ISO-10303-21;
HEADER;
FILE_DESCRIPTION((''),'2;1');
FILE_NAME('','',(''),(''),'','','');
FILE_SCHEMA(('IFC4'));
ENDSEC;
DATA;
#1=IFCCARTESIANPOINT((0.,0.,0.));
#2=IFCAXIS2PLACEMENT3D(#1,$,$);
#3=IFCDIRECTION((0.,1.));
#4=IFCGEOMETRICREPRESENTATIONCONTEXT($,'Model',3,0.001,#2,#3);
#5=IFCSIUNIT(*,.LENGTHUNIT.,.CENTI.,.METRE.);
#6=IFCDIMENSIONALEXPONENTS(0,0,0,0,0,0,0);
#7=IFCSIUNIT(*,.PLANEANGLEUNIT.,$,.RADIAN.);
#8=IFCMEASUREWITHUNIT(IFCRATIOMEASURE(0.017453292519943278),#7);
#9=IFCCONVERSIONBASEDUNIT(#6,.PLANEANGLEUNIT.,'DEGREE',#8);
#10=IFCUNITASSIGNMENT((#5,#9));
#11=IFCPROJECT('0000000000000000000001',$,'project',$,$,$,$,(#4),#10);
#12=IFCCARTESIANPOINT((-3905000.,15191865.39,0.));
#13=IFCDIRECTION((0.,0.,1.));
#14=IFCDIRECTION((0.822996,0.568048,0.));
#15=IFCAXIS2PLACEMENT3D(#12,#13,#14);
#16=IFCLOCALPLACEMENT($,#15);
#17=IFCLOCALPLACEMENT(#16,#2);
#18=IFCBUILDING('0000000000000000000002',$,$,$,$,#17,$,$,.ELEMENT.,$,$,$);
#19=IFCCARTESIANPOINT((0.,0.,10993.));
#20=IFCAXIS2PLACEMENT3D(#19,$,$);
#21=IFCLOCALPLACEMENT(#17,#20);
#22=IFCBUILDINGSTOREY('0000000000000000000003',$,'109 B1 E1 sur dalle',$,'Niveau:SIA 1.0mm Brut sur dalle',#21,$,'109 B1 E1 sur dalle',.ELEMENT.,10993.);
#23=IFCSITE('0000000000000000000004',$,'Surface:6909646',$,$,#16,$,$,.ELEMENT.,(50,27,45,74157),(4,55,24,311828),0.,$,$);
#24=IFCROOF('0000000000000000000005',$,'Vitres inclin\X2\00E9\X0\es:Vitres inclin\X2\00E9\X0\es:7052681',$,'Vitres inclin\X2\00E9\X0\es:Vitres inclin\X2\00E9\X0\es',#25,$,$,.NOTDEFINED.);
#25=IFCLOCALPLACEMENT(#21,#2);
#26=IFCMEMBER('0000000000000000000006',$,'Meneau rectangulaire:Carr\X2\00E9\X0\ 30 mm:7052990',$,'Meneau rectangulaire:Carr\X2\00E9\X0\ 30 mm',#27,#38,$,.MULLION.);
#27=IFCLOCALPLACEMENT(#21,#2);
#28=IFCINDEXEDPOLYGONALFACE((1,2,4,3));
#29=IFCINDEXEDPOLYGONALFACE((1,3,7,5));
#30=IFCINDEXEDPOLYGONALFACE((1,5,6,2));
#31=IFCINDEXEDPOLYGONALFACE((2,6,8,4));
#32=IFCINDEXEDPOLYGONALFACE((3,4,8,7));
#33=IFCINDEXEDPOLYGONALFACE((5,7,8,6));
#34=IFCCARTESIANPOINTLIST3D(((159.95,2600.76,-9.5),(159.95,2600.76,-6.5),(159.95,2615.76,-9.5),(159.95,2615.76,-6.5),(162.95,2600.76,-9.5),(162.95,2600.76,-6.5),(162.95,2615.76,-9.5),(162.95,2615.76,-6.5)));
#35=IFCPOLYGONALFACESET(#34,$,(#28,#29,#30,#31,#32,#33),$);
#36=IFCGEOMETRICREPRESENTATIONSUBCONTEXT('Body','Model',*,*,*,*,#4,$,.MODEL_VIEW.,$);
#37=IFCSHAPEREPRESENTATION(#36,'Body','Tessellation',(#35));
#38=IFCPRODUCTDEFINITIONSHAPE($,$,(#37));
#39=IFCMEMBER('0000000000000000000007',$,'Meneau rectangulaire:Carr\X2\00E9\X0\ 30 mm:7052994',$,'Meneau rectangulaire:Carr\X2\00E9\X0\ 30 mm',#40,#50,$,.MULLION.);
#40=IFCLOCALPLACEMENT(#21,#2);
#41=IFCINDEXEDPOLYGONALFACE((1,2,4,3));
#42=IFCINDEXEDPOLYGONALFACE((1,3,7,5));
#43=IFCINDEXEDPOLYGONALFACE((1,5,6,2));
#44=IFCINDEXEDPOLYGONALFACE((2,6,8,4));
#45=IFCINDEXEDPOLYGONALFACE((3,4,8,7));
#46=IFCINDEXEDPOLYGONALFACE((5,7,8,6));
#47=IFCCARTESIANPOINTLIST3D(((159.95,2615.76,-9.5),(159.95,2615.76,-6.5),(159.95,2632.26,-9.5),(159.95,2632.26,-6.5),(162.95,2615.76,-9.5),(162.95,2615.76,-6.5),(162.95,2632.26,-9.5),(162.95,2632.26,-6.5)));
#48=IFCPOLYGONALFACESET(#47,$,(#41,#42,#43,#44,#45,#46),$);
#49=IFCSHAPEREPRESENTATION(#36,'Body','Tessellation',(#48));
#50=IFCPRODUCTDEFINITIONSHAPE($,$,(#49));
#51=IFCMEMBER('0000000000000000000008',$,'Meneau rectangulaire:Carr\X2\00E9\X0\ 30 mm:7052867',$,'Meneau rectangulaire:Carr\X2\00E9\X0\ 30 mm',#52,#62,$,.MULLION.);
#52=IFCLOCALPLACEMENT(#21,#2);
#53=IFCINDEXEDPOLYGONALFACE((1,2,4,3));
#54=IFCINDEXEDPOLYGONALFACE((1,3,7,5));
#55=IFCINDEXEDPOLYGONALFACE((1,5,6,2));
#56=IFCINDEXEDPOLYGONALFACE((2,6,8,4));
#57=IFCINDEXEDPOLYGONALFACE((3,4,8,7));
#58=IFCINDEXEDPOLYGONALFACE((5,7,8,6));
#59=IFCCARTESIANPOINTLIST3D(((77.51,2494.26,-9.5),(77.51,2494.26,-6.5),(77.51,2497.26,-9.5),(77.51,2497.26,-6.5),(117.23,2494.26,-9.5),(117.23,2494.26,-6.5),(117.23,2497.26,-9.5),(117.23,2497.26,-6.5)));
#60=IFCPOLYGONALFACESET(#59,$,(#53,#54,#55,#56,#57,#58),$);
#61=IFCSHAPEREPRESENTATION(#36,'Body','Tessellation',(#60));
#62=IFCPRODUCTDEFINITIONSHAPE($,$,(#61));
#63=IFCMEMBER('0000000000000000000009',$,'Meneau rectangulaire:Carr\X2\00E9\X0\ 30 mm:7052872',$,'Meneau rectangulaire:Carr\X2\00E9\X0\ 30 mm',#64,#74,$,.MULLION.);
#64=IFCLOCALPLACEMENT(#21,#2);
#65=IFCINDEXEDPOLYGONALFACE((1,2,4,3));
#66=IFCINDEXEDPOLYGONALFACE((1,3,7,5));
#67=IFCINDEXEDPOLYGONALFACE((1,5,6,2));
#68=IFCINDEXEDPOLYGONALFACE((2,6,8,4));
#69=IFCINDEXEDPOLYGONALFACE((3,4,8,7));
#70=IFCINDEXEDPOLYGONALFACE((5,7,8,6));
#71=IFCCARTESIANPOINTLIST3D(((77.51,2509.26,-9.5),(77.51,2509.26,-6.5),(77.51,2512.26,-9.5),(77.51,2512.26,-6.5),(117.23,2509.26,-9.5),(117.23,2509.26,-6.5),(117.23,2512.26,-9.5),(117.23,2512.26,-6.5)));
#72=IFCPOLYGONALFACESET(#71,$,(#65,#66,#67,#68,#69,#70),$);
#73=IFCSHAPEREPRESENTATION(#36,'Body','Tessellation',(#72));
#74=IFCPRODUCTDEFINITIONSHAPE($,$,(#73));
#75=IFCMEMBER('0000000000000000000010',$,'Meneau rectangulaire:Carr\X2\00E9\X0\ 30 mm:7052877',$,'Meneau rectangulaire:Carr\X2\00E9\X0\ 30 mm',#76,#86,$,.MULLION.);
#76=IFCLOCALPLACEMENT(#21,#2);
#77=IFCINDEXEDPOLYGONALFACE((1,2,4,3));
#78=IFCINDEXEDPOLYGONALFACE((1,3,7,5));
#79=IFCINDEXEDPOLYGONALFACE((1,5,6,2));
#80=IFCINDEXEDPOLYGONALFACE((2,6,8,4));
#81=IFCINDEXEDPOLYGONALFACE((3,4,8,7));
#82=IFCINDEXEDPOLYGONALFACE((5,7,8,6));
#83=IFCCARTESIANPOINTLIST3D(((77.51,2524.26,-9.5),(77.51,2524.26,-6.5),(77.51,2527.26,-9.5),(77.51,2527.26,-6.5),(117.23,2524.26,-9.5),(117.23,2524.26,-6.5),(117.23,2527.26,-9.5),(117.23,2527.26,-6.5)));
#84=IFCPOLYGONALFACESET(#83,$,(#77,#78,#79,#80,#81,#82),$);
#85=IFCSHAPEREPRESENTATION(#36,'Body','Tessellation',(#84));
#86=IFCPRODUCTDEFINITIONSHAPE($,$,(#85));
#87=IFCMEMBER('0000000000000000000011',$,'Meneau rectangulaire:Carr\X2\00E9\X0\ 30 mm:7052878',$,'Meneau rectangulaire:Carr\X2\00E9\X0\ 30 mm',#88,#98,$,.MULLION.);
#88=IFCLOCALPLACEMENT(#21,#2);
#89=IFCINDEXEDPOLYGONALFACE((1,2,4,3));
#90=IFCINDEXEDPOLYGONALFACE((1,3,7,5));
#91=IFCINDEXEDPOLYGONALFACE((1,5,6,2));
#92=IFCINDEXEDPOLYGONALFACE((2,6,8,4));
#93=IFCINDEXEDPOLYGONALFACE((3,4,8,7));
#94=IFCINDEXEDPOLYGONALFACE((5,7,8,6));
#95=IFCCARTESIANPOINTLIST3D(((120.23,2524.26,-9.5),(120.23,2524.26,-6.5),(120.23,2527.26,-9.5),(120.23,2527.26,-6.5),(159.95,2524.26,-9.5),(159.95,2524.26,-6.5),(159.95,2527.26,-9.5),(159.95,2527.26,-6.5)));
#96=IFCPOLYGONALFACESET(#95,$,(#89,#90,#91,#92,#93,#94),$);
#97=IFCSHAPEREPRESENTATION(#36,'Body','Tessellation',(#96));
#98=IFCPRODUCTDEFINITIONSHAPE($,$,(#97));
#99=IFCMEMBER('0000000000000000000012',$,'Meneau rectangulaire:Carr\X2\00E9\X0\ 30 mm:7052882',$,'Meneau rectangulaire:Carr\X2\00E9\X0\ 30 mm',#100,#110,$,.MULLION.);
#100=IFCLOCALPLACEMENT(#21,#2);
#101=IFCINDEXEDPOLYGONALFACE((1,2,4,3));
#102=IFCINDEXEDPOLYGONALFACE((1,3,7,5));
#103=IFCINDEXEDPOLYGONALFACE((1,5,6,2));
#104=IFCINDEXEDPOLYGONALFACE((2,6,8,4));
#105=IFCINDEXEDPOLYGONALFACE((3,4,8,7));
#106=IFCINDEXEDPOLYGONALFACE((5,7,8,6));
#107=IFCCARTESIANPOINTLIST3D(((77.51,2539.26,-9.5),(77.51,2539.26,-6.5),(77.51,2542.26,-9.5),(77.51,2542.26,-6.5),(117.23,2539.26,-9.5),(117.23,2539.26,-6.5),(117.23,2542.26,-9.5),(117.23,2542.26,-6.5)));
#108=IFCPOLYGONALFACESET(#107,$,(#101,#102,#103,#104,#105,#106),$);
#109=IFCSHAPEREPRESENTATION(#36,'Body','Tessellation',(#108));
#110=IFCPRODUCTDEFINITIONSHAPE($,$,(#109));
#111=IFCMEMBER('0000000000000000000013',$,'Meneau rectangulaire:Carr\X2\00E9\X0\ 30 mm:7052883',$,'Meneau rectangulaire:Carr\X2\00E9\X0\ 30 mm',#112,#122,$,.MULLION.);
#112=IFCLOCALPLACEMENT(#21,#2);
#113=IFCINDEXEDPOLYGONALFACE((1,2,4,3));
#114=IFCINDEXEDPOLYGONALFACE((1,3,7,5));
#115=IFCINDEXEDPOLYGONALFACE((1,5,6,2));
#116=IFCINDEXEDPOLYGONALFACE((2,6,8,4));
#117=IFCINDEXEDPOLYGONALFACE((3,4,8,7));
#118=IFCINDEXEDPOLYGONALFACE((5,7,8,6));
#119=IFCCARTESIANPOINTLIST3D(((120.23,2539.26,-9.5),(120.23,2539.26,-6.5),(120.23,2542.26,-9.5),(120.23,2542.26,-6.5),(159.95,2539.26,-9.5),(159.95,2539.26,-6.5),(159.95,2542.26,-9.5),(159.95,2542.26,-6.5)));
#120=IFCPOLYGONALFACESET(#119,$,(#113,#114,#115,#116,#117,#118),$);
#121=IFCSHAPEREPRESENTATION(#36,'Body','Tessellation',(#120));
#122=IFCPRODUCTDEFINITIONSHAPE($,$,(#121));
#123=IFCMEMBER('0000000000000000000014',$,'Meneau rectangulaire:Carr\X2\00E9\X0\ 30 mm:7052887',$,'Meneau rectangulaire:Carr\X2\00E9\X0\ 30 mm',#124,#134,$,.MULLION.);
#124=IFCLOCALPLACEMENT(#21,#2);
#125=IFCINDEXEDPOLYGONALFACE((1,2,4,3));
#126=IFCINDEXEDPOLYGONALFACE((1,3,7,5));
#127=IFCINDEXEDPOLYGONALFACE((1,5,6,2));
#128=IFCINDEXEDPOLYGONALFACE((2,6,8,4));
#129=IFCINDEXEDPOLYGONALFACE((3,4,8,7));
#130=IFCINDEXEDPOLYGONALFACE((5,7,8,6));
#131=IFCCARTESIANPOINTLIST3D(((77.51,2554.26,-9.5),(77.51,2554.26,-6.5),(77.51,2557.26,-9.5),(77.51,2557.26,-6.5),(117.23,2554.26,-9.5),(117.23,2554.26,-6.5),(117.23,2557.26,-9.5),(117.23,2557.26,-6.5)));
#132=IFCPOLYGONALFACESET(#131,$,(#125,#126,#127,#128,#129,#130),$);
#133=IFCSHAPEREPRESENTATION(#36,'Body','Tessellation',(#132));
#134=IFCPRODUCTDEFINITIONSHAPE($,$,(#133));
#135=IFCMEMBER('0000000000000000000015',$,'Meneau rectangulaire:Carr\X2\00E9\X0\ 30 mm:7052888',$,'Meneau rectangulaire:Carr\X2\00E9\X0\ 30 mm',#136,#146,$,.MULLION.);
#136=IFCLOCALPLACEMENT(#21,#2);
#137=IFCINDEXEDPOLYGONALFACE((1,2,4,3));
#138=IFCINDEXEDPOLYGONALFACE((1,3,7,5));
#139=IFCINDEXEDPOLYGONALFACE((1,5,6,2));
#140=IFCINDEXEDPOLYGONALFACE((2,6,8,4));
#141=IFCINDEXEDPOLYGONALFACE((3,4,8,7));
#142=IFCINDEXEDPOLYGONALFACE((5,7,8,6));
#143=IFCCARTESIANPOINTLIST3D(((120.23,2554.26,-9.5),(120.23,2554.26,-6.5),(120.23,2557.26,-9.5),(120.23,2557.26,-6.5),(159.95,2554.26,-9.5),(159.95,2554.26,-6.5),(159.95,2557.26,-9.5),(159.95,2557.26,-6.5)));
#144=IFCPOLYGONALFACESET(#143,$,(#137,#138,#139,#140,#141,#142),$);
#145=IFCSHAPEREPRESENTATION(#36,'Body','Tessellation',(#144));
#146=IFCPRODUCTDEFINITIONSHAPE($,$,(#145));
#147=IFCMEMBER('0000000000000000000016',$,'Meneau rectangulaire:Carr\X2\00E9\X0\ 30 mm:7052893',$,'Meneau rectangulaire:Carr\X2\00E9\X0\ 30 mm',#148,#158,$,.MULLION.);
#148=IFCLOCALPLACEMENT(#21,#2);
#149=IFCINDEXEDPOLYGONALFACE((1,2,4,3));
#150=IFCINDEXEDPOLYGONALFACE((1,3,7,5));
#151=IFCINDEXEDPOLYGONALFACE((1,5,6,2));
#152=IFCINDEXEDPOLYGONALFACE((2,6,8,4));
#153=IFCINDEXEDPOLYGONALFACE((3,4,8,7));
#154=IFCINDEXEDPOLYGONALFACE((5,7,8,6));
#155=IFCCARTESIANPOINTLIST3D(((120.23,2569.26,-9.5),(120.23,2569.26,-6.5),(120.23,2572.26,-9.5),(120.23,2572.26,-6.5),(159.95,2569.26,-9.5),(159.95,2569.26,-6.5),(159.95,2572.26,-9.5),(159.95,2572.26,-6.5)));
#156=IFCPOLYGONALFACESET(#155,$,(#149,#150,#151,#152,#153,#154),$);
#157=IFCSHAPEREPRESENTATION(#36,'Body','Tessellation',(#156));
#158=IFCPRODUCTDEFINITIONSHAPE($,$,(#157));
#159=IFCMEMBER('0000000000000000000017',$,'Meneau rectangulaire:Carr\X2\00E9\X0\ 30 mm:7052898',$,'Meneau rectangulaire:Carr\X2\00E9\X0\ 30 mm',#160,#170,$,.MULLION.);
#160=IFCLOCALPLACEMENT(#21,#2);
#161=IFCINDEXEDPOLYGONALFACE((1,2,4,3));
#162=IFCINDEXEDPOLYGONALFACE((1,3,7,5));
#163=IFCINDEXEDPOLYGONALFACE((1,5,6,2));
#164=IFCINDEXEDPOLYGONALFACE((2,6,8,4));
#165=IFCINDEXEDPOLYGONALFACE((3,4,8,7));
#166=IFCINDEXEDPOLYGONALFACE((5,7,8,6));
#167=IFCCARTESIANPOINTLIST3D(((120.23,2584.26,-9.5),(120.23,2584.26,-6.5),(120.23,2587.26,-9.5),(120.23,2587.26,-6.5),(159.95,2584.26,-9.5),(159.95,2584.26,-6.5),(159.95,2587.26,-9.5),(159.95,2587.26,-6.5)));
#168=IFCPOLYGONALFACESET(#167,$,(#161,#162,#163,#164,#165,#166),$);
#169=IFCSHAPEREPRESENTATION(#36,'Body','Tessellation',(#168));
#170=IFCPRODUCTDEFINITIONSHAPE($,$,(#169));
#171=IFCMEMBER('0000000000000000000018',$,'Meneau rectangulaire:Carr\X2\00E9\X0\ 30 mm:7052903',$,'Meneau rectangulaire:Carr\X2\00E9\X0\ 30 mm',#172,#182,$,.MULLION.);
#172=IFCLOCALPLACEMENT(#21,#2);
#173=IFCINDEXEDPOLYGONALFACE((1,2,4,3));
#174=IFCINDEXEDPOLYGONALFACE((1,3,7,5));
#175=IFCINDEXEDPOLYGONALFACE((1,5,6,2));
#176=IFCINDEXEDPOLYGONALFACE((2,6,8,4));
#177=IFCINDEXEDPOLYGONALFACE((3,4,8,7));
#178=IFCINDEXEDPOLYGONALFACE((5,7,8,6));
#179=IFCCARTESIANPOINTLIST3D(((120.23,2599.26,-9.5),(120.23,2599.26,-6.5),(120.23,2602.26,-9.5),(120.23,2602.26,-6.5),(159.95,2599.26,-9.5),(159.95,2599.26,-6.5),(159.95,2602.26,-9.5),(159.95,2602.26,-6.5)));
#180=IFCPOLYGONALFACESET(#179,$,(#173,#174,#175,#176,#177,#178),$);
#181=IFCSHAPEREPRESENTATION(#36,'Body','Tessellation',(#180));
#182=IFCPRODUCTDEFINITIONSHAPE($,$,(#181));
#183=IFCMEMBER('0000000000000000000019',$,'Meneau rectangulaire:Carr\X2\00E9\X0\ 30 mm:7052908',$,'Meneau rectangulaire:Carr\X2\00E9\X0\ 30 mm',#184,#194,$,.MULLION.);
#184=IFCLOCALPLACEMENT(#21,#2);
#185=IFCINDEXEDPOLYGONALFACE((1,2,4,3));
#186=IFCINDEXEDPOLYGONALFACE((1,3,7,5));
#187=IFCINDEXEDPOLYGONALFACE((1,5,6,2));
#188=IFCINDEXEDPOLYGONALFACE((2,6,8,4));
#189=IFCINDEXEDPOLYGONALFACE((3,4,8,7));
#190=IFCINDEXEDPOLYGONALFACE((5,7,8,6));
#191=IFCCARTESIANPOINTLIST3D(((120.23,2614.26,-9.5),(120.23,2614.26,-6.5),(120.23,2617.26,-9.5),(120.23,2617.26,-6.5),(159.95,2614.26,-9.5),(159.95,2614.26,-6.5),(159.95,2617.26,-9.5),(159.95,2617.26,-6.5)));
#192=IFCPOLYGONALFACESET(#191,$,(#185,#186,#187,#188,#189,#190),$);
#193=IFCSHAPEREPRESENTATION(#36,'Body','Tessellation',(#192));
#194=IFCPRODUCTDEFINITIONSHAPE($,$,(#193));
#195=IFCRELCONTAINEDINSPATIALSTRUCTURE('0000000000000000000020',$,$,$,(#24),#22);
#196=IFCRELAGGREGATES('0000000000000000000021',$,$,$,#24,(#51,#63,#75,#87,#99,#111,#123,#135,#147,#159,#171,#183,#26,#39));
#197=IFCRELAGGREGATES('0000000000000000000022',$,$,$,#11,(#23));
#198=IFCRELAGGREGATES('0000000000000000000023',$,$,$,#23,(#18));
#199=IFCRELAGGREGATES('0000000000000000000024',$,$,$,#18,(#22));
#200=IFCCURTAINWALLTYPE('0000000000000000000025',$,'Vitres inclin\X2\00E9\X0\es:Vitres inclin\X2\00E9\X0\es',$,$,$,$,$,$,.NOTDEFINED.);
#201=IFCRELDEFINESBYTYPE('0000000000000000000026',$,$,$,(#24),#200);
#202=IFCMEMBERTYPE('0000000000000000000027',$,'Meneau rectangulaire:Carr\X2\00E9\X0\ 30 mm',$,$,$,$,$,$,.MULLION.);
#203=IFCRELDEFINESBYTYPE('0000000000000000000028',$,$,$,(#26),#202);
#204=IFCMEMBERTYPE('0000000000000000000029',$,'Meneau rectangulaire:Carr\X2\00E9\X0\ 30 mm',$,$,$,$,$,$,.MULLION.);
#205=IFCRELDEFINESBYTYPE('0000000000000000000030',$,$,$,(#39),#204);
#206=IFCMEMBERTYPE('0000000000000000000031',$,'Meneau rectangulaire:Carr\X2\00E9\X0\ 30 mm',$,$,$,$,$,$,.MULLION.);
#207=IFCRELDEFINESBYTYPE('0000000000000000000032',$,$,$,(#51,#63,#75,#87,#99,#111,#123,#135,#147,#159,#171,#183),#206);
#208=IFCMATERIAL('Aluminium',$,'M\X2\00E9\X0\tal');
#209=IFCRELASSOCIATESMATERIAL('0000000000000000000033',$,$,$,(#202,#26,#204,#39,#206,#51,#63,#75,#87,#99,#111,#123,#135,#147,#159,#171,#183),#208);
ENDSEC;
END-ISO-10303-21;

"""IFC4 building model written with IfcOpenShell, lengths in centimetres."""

from ifc_helpers import new_model, entity, si_unit, converted_unit, direction, frame, origin, place, context, subcontext, project, spatial, indexed_curve, outline, extrude, source, transform, mapped, material, type_object, type_shapes, element, aggregate, save


model = new_model("IFC4")

# Units and contexts
model_context = context("Model", 3, precision=0.001, world=origin(), true_north=direction((0.0, 1.0)))
body_context = subcontext(model_context, "Body", "Model", "MODEL_VIEW")
ifc_project = project(units=[si_unit("LENGTHUNIT", "METRE", prefix="CENTI"), converted_unit("PLANEANGLEUNIT", "DEGREE", entity("IfcRatioMeasure", 0.017453292519943278), si_unit("PLANEANGLEUNIT", "RADIAN"), dimensions=[0, 0, 0, 0, 0, 0, 0])], contexts=[model_context])

# Site, building, storey
site_placement = place(None, frame((-3905000.0, 15191865.39, 0.0), z_axis=(0.0, 0.0, 1.0), x_axis=(0.822996, 0.568048, 0.0)))
site = spatial("IfcSite", under=ifc_project, at=site_placement, Name="Surface:6909646", CompositionType="ELEMENT", RefLatitude=(50, 27, 45, 74157), RefLongitude=(4, 55, 24, 311828), RefElevation=0.0)
building_placement = place(site_placement, origin())
building = spatial("IfcBuilding", under=site, at=building_placement, CompositionType="ELEMENT")
storey_placement = place(building_placement, frame((0.0, 0.0, 10993.0)))
storey = spatial("IfcBuildingStorey", under=building, at=storey_placement, Name="109 B1 E1 sur dalle", ObjectType="Niveau:SIA 1.0mm Brut sur dalle", LongName="109 B1 E1 sur dalle", CompositionType="ELEMENT", Elevation=10993.0)

# Roof, members
curtain_wall_type = type_object("IfcCurtainWallType", Name="Vitres inclinées:Vitres inclinées", PredefinedType="NOTDEFINED")
roof_placement = place(storey_placement, frame((0.0, 0.0, -10993.0)))
roof = element("IfcRoof", 1, at=roof_placement, inside=storey, type_object=curtain_wall_type, Name="Vitres inclinées:Vitres inclinées:7052681", ObjectType="Vitres inclinées:Vitres inclinées", PredefinedType="NOTDEFINED")
ifc_material = material(Name="Aluminium", Category="Métal")
member_type_1 = type_object("IfcMemberType", Name="Meneau rectangulaire:Carré 30 mm", PredefinedType="MULLION", material=ifc_material)
shared_shape_1 = source(origin(), body_context, "Body", "SweptSolid", [
    extrude(outline(indexed_curve([(-1.5, -1.5), (1.5, -1.5), (1.5, 1.5), (-1.5, 1.5), (-1.5, -1.5)], self_intersect=False)), frame((0.0, 0.0, -15.0), z_axis=(0.0, 0.0, 1.0), x_axis=(0.0, -1.0, 0.0)), (0.0, 0.0, 1.0), 15.0),
])
type_shapes(member_type_1, [shared_shape_1])
member_1_placement = place(roof_placement, frame((161.45, 2615.76, 10985.0), z_axis=(0.0, 1.0, 0.0), x_axis=(1.0, 0.0, 0.0)))
member_1 = element("IfcMember", 2, at=member_1_placement, type_object=member_type_1, material=ifc_material, Name="Meneau rectangulaire:Carré 30 mm:7052990", ObjectType="Meneau rectangulaire:Carré 30 mm", PredefinedType="MULLION", context=body_context, shape_type="MappedRepresentation", body=[
    mapped(shared_shape_1, transform((0.0, 0.0, 0.0), scale=1.0)),
])
member_type_2 = type_object("IfcMemberType", Name="Meneau rectangulaire:Carré 30 mm", PredefinedType="MULLION", material=ifc_material)
shared_shape_2 = source(origin(), body_context, "Body", "SweptSolid", [
    extrude(outline(indexed_curve([(-1.5, -1.5), (1.5, -1.5), (1.5, 1.5), (-1.5, 1.5), (-1.5, -1.5)], self_intersect=False)), frame((0.0, 0.0, -16.5), z_axis=(0.0, 0.0, 1.0), x_axis=(0.0, -1.0, 0.0)), (0.0, 0.0, 1.0), 16.5),
])
type_shapes(member_type_2, [shared_shape_2])
member_2_placement = place(roof_placement, frame((161.45, 2632.26, 10985.0), z_axis=(0.0, 1.0, 0.0), x_axis=(1.0, 0.0, 0.0)))
member_2 = element("IfcMember", 3, at=member_2_placement, type_object=member_type_2, material=ifc_material, Name="Meneau rectangulaire:Carré 30 mm:7052994", ObjectType="Meneau rectangulaire:Carré 30 mm", PredefinedType="MULLION", context=body_context, shape_type="MappedRepresentation", body=[
    mapped(shared_shape_2, transform((0.0, 0.0, 0.0), scale=1.0)),
])
member_type_3 = type_object("IfcMemberType", Name="Meneau rectangulaire:Carré 30 mm", PredefinedType="MULLION", material=ifc_material)
shared_shape_3 = source(origin(), body_context, "Body", "SweptSolid", [
    extrude(outline(indexed_curve([(-1.5, -1.5), (1.5, -1.5), (1.5, 1.5), (-1.5, 1.5), (-1.5, -1.5)], self_intersect=False)), frame((0.0, 0.0, -39.72), z_axis=(0.0, 0.0, 1.0), x_axis=(0.0, -1.0, 0.0)), (0.0, 0.0, 1.0), 39.72),
])
type_shapes(member_type_3, [shared_shape_3])
member_3_placement = place(roof_placement, frame((77.51, 2495.76, 10985.0), z_axis=(-1.0, 0.0, 0.0), x_axis=(0.0, 1.0, 0.0)))
member_3 = element("IfcMember", 4, at=member_3_placement, type_object=member_type_3, material=ifc_material, Name="Meneau rectangulaire:Carré 30 mm:7052867", ObjectType="Meneau rectangulaire:Carré 30 mm", PredefinedType="MULLION", context=body_context, shape_type="MappedRepresentation", body=[
    mapped(shared_shape_3, transform((0.0, 0.0, 0.0), scale=1.0)),
])
member_4_placement = place(roof_placement, frame((77.51, 2510.76, 10985.0), z_axis=(-1.0, 0.0, 0.0), x_axis=(0.0, 1.0, 0.0)))
member_4 = element("IfcMember", 5, at=member_4_placement, type_object=member_type_3, material=ifc_material, Name="Meneau rectangulaire:Carré 30 mm:7052872", ObjectType="Meneau rectangulaire:Carré 30 mm", PredefinedType="MULLION", context=body_context, shape_type="MappedRepresentation", body=[
    mapped(shared_shape_3, transform((0.0, 0.0, 0.0), scale=1.0)),
])
member_5_placement = place(roof_placement, frame((77.51, 2525.76, 10985.0), z_axis=(-1.0, 0.0, 0.0), x_axis=(0.0, 1.0, 0.0)))
member_5 = element("IfcMember", 6, at=member_5_placement, type_object=member_type_3, material=ifc_material, Name="Meneau rectangulaire:Carré 30 mm:7052877", ObjectType="Meneau rectangulaire:Carré 30 mm", PredefinedType="MULLION", context=body_context, shape_type="MappedRepresentation", body=[
    mapped(shared_shape_3, transform((0.0, 0.0, 0.0), scale=1.0)),
])
member_6_placement = place(roof_placement, frame((120.23, 2525.76, 10985.0), z_axis=(-1.0, 0.0, 0.0), x_axis=(0.0, 1.0, 0.0)))
member_6 = element("IfcMember", 7, at=member_6_placement, type_object=member_type_3, material=ifc_material, Name="Meneau rectangulaire:Carré 30 mm:7052878", ObjectType="Meneau rectangulaire:Carré 30 mm", PredefinedType="MULLION", context=body_context, shape_type="MappedRepresentation", body=[
    mapped(shared_shape_3, transform((0.0, 0.0, 0.0), scale=1.0)),
])
member_7_placement = place(roof_placement, frame((77.51, 2540.76, 10985.0), z_axis=(-1.0, 0.0, 0.0), x_axis=(0.0, 1.0, 0.0)))
member_7 = element("IfcMember", 8, at=member_7_placement, type_object=member_type_3, material=ifc_material, Name="Meneau rectangulaire:Carré 30 mm:7052882", ObjectType="Meneau rectangulaire:Carré 30 mm", PredefinedType="MULLION", context=body_context, shape_type="MappedRepresentation", body=[
    mapped(shared_shape_3, transform((0.0, 0.0, 0.0), scale=1.0)),
])
member_8_placement = place(roof_placement, frame((120.23, 2540.76, 10985.0), z_axis=(-1.0, 0.0, 0.0), x_axis=(0.0, 1.0, 0.0)))
member_8 = element("IfcMember", 9, at=member_8_placement, type_object=member_type_3, material=ifc_material, Name="Meneau rectangulaire:Carré 30 mm:7052883", ObjectType="Meneau rectangulaire:Carré 30 mm", PredefinedType="MULLION", context=body_context, shape_type="MappedRepresentation", body=[
    mapped(shared_shape_3, transform((0.0, 0.0, 0.0), scale=1.0)),
])
member_9_placement = place(roof_placement, frame((77.51, 2555.76, 10985.0), z_axis=(-1.0, 0.0, 0.0), x_axis=(0.0, 1.0, 0.0)))
member_9 = element("IfcMember", 10, at=member_9_placement, type_object=member_type_3, material=ifc_material, Name="Meneau rectangulaire:Carré 30 mm:7052887", ObjectType="Meneau rectangulaire:Carré 30 mm", PredefinedType="MULLION", context=body_context, shape_type="MappedRepresentation", body=[
    mapped(shared_shape_3, transform((0.0, 0.0, 0.0), scale=1.0)),
])
member_10_placement = place(roof_placement, frame((120.23, 2555.76, 10985.0), z_axis=(-1.0, 0.0, 0.0), x_axis=(0.0, 1.0, 0.0)))
member_10 = element("IfcMember", 11, at=member_10_placement, type_object=member_type_3, material=ifc_material, Name="Meneau rectangulaire:Carré 30 mm:7052888", ObjectType="Meneau rectangulaire:Carré 30 mm", PredefinedType="MULLION", context=body_context, shape_type="MappedRepresentation", body=[
    mapped(shared_shape_3, transform((0.0, 0.0, 0.0), scale=1.0)),
])
member_11_placement = place(roof_placement, frame((120.23, 2570.76, 10985.0), z_axis=(-1.0, 0.0, 0.0), x_axis=(0.0, 1.0, 0.0)))
member_11 = element("IfcMember", 12, at=member_11_placement, type_object=member_type_3, material=ifc_material, Name="Meneau rectangulaire:Carré 30 mm:7052893", ObjectType="Meneau rectangulaire:Carré 30 mm", PredefinedType="MULLION", context=body_context, shape_type="MappedRepresentation", body=[
    mapped(shared_shape_3, transform((0.0, 0.0, 0.0), scale=1.0)),
])
member_12_placement = place(roof_placement, frame((120.23, 2585.76, 10985.0), z_axis=(-1.0, 0.0, 0.0), x_axis=(0.0, 1.0, 0.0)))
member_12 = element("IfcMember", 13, at=member_12_placement, type_object=member_type_3, material=ifc_material, Name="Meneau rectangulaire:Carré 30 mm:7052898", ObjectType="Meneau rectangulaire:Carré 30 mm", PredefinedType="MULLION", context=body_context, shape_type="MappedRepresentation", body=[
    mapped(shared_shape_3, transform((0.0, 0.0, 0.0), scale=1.0)),
])
member_13_placement = place(roof_placement, frame((120.23, 2600.76, 10985.0), z_axis=(-1.0, 0.0, 0.0), x_axis=(0.0, 1.0, 0.0)))
member_13 = element("IfcMember", 14, at=member_13_placement, type_object=member_type_3, material=ifc_material, Name="Meneau rectangulaire:Carré 30 mm:7052903", ObjectType="Meneau rectangulaire:Carré 30 mm", PredefinedType="MULLION", context=body_context, shape_type="MappedRepresentation", body=[
    mapped(shared_shape_3, transform((0.0, 0.0, 0.0), scale=1.0)),
])
member_14_placement = place(roof_placement, frame((120.23, 2615.76, 10985.0), z_axis=(-1.0, 0.0, 0.0), x_axis=(0.0, 1.0, 0.0)))
member_14 = element("IfcMember", 15, at=member_14_placement, type_object=member_type_3, material=ifc_material, Name="Meneau rectangulaire:Carré 30 mm:7052908", ObjectType="Meneau rectangulaire:Carré 30 mm", PredefinedType="MULLION", context=body_context, shape_type="MappedRepresentation", body=[
    mapped(shared_shape_3, transform((0.0, 0.0, 0.0), scale=1.0)),
])
aggregate(roof, [member_3, member_4, member_5, member_6, member_7, member_8, member_9, member_10, member_11, member_12, member_13, member_14, member_1, member_2])

save(model, "model.ifc")
